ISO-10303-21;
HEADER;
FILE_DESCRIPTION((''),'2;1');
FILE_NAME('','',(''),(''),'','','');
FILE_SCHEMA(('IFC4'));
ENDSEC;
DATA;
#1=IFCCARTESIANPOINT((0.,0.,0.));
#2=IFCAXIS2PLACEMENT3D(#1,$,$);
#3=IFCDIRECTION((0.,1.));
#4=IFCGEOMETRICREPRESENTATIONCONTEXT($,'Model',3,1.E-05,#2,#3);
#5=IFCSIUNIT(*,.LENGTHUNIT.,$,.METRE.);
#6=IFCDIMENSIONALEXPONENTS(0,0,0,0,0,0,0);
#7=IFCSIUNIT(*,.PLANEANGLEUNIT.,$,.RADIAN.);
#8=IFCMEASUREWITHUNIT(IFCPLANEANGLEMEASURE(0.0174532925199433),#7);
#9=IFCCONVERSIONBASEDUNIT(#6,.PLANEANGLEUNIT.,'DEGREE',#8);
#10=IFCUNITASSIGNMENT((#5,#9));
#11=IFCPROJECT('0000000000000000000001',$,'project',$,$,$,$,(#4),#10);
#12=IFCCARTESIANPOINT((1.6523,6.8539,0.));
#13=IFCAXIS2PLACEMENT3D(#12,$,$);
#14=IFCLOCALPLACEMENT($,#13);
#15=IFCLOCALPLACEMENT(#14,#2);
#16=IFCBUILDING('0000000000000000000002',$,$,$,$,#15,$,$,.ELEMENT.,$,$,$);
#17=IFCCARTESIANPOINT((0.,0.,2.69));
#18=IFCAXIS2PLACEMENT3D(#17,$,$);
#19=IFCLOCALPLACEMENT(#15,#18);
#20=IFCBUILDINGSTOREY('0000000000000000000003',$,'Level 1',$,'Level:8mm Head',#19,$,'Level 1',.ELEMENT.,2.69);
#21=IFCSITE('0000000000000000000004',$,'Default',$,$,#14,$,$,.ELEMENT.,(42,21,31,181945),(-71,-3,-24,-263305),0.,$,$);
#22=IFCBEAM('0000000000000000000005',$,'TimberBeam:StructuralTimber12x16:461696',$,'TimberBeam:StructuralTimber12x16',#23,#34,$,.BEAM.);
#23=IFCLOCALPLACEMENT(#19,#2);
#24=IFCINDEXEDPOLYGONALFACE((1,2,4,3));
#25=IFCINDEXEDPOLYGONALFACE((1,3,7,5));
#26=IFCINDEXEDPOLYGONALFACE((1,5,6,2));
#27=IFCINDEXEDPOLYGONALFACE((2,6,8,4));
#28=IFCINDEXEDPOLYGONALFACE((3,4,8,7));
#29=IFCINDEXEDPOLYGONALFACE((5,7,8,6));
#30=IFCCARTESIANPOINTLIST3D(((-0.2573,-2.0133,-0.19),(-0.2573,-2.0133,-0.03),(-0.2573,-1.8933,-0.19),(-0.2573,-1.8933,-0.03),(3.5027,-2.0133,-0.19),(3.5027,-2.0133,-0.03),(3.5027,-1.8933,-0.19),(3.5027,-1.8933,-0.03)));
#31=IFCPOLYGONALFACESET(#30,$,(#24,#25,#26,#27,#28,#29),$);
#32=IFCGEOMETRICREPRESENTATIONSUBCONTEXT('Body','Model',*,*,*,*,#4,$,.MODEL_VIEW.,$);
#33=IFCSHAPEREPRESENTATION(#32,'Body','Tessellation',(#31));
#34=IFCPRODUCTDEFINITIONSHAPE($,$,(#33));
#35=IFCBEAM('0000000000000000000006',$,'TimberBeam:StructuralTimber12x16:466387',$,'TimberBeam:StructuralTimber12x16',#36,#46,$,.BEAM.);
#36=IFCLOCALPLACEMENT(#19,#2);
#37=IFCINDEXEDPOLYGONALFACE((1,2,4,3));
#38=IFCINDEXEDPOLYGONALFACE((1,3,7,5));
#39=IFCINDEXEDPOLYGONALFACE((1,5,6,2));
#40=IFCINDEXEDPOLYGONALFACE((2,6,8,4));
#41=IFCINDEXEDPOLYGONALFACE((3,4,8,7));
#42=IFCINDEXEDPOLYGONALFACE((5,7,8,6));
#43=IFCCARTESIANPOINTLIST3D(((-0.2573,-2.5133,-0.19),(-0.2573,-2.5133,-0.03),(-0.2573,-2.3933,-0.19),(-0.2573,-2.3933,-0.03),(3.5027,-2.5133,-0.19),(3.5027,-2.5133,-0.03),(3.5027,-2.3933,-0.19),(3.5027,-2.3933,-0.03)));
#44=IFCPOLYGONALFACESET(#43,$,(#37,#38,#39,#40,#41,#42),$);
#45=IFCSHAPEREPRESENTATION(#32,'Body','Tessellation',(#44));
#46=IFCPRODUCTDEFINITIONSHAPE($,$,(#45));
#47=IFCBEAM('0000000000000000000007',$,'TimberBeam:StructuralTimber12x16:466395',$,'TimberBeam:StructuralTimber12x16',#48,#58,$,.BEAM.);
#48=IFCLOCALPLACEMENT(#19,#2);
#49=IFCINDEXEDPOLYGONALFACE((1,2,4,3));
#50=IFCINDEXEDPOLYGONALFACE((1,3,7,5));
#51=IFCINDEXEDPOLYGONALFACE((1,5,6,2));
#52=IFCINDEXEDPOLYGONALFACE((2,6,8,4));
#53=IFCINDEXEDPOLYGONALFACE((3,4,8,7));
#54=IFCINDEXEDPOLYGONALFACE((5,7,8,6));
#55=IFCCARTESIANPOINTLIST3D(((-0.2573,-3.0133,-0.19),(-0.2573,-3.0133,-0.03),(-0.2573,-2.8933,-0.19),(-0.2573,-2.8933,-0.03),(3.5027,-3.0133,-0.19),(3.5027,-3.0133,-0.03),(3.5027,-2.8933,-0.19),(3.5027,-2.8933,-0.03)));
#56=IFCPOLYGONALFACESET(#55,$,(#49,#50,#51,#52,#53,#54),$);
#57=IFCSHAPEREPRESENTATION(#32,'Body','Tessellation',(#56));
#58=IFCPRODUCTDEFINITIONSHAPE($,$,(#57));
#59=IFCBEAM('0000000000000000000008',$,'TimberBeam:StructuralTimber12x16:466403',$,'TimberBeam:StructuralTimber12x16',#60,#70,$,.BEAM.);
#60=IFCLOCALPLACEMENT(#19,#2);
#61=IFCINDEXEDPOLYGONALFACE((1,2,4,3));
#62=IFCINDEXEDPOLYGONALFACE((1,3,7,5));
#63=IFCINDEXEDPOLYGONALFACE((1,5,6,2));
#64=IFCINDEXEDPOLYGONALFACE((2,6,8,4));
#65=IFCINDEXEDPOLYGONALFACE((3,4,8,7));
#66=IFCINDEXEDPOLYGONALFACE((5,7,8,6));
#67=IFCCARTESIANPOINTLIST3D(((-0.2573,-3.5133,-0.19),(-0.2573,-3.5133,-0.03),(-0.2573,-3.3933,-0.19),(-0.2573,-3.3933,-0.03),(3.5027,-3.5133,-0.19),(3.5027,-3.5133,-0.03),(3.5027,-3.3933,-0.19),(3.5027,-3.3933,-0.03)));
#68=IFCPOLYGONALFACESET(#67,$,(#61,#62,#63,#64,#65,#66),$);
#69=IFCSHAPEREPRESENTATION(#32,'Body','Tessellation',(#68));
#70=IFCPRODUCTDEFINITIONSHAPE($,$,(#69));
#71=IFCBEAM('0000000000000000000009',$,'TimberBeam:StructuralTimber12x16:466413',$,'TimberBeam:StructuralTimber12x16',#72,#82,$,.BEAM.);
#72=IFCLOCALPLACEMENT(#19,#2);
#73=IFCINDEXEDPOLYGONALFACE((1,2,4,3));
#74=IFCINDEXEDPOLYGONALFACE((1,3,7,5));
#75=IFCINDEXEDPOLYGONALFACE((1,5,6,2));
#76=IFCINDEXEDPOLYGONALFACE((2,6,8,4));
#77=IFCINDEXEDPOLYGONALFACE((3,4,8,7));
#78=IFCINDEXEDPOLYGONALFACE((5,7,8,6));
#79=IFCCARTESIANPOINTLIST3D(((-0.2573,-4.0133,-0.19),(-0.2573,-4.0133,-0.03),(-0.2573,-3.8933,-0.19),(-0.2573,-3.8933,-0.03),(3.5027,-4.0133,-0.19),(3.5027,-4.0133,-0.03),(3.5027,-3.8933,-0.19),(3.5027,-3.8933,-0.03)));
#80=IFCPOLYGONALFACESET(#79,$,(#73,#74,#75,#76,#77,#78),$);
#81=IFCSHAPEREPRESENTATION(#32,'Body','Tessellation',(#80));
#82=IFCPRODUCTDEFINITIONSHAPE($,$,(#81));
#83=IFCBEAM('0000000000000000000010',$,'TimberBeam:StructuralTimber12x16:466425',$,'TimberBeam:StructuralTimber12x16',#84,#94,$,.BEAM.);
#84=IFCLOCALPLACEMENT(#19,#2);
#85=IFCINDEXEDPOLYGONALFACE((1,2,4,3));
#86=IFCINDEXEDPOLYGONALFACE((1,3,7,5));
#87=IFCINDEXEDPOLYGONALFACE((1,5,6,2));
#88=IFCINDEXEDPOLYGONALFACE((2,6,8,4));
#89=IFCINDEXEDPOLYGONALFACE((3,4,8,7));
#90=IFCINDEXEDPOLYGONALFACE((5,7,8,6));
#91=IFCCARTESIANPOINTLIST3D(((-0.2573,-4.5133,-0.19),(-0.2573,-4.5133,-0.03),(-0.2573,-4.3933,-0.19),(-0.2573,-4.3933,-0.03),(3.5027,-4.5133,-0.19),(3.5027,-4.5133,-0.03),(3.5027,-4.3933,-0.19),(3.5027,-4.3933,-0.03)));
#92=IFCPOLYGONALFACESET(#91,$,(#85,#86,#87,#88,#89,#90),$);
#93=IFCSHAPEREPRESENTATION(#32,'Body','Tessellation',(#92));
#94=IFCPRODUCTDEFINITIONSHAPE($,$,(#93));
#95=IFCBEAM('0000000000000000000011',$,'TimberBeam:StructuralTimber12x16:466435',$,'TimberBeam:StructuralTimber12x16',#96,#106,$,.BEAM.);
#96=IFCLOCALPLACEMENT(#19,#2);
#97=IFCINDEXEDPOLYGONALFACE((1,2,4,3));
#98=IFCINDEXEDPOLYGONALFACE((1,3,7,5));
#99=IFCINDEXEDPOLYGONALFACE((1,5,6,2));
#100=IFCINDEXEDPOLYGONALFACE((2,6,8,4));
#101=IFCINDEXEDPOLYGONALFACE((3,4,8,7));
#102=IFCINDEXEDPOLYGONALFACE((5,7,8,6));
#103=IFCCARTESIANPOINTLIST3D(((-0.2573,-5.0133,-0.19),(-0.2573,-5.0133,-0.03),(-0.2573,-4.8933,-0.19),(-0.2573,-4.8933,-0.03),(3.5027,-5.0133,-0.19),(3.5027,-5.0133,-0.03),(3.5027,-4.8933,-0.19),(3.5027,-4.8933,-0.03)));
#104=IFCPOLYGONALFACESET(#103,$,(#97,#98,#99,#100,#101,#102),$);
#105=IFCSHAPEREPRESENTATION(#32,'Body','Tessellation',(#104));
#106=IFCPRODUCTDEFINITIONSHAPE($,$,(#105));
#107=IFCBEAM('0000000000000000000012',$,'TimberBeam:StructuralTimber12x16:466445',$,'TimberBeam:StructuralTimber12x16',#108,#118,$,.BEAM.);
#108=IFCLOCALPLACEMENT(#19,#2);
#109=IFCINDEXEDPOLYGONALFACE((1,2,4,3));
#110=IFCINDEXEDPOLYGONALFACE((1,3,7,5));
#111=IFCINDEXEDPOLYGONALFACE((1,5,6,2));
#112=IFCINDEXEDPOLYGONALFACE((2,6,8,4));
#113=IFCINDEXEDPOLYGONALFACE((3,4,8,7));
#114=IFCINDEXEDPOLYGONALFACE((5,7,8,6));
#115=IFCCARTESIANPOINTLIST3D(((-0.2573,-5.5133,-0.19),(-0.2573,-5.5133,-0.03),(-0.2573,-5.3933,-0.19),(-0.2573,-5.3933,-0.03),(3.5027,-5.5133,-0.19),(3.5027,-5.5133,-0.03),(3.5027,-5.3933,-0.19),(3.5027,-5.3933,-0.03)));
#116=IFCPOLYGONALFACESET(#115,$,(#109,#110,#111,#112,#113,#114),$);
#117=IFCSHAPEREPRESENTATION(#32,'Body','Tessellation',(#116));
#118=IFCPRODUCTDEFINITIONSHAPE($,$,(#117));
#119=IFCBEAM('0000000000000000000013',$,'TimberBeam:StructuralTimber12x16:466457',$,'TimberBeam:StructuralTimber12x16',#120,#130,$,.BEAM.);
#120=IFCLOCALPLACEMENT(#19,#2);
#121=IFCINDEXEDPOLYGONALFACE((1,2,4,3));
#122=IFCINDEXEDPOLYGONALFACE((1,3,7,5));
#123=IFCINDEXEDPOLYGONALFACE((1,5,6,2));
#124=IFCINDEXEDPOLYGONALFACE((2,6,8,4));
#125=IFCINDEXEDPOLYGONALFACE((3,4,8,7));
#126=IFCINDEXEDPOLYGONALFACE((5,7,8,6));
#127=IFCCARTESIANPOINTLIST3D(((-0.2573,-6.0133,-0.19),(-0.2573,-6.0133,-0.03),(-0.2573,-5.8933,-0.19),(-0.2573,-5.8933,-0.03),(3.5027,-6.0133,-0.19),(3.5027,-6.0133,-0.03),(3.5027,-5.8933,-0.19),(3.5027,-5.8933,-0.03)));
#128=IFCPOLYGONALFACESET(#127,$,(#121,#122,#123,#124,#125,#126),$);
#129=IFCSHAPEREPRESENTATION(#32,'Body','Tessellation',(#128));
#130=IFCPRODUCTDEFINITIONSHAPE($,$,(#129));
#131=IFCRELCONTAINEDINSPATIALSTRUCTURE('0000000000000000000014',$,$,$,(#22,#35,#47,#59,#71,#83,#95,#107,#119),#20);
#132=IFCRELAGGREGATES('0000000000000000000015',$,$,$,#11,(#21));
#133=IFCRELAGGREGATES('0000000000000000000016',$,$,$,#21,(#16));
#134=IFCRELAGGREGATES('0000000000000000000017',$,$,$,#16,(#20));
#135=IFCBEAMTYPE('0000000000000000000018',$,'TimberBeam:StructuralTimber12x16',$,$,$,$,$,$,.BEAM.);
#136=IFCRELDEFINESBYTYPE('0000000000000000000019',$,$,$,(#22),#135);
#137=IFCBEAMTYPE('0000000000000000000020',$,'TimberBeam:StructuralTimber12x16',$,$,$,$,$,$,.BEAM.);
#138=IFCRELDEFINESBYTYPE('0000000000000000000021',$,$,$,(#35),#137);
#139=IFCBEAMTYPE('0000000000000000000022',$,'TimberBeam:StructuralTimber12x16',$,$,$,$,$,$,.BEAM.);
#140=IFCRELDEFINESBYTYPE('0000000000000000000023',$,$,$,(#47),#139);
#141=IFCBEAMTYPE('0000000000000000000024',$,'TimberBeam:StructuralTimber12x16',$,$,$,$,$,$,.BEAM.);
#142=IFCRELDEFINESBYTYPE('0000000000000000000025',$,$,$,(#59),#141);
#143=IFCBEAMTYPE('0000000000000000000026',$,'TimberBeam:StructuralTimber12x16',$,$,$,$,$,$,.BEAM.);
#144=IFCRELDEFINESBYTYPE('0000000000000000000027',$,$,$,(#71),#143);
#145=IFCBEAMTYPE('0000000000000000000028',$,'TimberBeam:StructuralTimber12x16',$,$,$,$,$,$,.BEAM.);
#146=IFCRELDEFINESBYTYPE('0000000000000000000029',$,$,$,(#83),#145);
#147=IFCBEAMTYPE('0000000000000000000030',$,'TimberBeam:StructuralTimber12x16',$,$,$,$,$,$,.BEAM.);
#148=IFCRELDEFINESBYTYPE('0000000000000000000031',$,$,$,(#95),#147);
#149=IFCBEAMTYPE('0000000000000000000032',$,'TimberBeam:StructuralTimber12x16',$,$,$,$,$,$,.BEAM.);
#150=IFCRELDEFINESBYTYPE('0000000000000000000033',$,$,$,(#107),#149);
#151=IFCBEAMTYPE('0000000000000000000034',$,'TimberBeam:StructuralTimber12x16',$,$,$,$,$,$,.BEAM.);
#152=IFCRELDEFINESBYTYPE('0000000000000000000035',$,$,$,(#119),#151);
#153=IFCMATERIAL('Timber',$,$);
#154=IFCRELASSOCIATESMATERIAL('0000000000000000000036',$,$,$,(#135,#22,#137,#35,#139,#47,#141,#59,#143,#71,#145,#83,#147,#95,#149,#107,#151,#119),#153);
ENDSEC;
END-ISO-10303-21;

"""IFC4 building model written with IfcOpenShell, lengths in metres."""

from ifc_helpers import new_model, entity, si_unit, converted_unit, direction, frame, origin, place, context, subcontext, project, spatial, indexed_curve, outline, extrude, source, transform, mapped, material, type_object, type_shapes, element, save


model = new_model("IFC4")

# Units and contexts
model_context = context("Model", 3, precision=1e-05, world=origin(), true_north=direction((0.0, 1.0)))
body_context = subcontext(model_context, "Body", "Model", "MODEL_VIEW")
ifc_project = project(units=[si_unit("LENGTHUNIT", "METRE"), converted_unit("PLANEANGLEUNIT", "DEGREE", entity("IfcPlaneAngleMeasure", 0.0174532925199433), si_unit("PLANEANGLEUNIT", "RADIAN"), dimensions=[0, 0, 0, 0, 0, 0, 0])], contexts=[model_context])

# Site, building, storey
site_placement = place(None, frame((1.6523, 6.8539, 0.0)))
site = spatial("IfcSite", under=ifc_project, at=site_placement, Name="Default", CompositionType="ELEMENT", RefLatitude=(42, 21, 31, 181945), RefLongitude=(-71, -3, -24, -263305), RefElevation=0.0)
building_placement = place(site_placement, origin())
building = spatial("IfcBuilding", under=site, at=building_placement, CompositionType="ELEMENT")
storey_placement = place(building_placement, frame((0.0, 0.0, 2.69)))
storey = spatial("IfcBuildingStorey", under=building, at=storey_placement, Name="Level 1", ObjectType="Level:8mm Head", LongName="Level 1", CompositionType="ELEMENT", Elevation=2.69)

# Beams
ifc_material = material(Name="Timber")
beam_type_1 = type_object("IfcBeamType", Name="TimberBeam:StructuralTimber12x16", PredefinedType="BEAM", material=ifc_material)
shared_shape_1 = source(origin(), body_context, "Body", "SweptSolid", [
    extrude(outline(indexed_curve([(-0.08, -0.06), (0.08, -0.06), (0.08, 0.06), (-0.08, 0.06), (-0.08, -0.06)], self_intersect=False)), frame((-0.2573, -1.9533, 2.58), z_axis=(1.0, 0.0, 0.0), x_axis=(0.0, 0.0, -1.0)), (0.0, 0.0, 1.0), 3.76),
])
type_shapes(beam_type_1, [shared_shape_1])
beam_1_placement = place(storey_placement, frame((0.0, 0.0, -2.69)))
element("IfcBeam", 1, at=beam_1_placement, inside=storey, type_object=beam_type_1, material=ifc_material, Name="TimberBeam:StructuralTimber12x16:461696", ObjectType="TimberBeam:StructuralTimber12x16", PredefinedType="BEAM", context=body_context, shape_type="MappedRepresentation", body=[
    mapped(shared_shape_1, transform((0.0, 0.0, 0.0), scale=1.0)),
])
beam_type_2 = type_object("IfcBeamType", Name="TimberBeam:StructuralTimber12x16", PredefinedType="BEAM", material=ifc_material)
shared_shape_2 = source(origin(), body_context, "Body", "SweptSolid", [
    extrude(outline(indexed_curve([(-0.08, -0.06), (0.08, -0.06), (0.08, 0.06), (-0.08, 0.06), (-0.08, -0.06)], self_intersect=False)), frame((-0.2573, -2.4533, 2.58), z_axis=(1.0, 0.0, 0.0), x_axis=(0.0, 0.0, -1.0)), (0.0, 0.0, 1.0), 3.76),
])
type_shapes(beam_type_2, [shared_shape_2])
beam_2_placement = place(storey_placement, frame((0.0, 0.0, -2.69)))
element("IfcBeam", 2, at=beam_2_placement, inside=storey, type_object=beam_type_2, material=ifc_material, Name="TimberBeam:StructuralTimber12x16:466387", ObjectType="TimberBeam:StructuralTimber12x16", PredefinedType="BEAM", context=body_context, shape_type="MappedRepresentation", body=[
    mapped(shared_shape_2, transform((0.0, 0.0, 0.0), scale=1.0)),
])
beam_type_3 = type_object("IfcBeamType", Name="TimberBeam:StructuralTimber12x16", PredefinedType="BEAM", material=ifc_material)
shared_shape_3 = source(origin(), body_context, "Body", "SweptSolid", [
    extrude(outline(indexed_curve([(-0.08, -0.06), (0.08, -0.06), (0.08, 0.06), (-0.08, 0.06), (-0.08, -0.06)], self_intersect=False)), frame((-0.2573, -2.9533, 2.58), z_axis=(1.0, 0.0, 0.0), x_axis=(0.0, 0.0, -1.0)), (0.0, 0.0, 1.0), 3.76),
])
type_shapes(beam_type_3, [shared_shape_3])
beam_3_placement = place(storey_placement, frame((0.0, 0.0, -2.69)))
element("IfcBeam", 3, at=beam_3_placement, inside=storey, type_object=beam_type_3, material=ifc_material, Name="TimberBeam:StructuralTimber12x16:466395", ObjectType="TimberBeam:StructuralTimber12x16", PredefinedType="BEAM", context=body_context, shape_type="MappedRepresentation", body=[
    mapped(shared_shape_3, transform((0.0, 0.0, 0.0), scale=1.0)),
])
beam_type_4 = type_object("IfcBeamType", Name="TimberBeam:StructuralTimber12x16", PredefinedType="BEAM", material=ifc_material)
shared_shape_4 = source(origin(), body_context, "Body", "SweptSolid", [
    extrude(outline(indexed_curve([(-0.08, -0.06), (0.08, -0.06), (0.08, 0.06), (-0.08, 0.06), (-0.08, -0.06)], self_intersect=False)), frame((-0.2573, -3.4533, 2.58), z_axis=(1.0, 0.0, 0.0), x_axis=(0.0, 0.0, -1.0)), (0.0, 0.0, 1.0), 3.76),
])
type_shapes(beam_type_4, [shared_shape_4])
beam_4_placement = place(storey_placement, frame((0.0, 0.0, -2.69)))
element("IfcBeam", 4, at=beam_4_placement, inside=storey, type_object=beam_type_4, material=ifc_material, Name="TimberBeam:StructuralTimber12x16:466403", ObjectType="TimberBeam:StructuralTimber12x16", PredefinedType="BEAM", context=body_context, shape_type="MappedRepresentation", body=[
    mapped(shared_shape_4, transform((0.0, 0.0, 0.0), scale=1.0)),
])
beam_type_5 = type_object("IfcBeamType", Name="TimberBeam:StructuralTimber12x16", PredefinedType="BEAM", material=ifc_material)
shared_shape_5 = source(origin(), body_context, "Body", "SweptSolid", [
    extrude(outline(indexed_curve([(-0.08, -0.06), (0.08, -0.06), (0.08, 0.06), (-0.08, 0.06), (-0.08, -0.06)], self_intersect=False)), frame((-0.2573, -3.9533, 2.58), z_axis=(1.0, 0.0, 0.0), x_axis=(0.0, 0.0, -1.0)), (0.0, 0.0, 1.0), 3.76),
])
type_shapes(beam_type_5, [shared_shape_5])
beam_5_placement = place(storey_placement, frame((0.0, 0.0, -2.69)))
element("IfcBeam", 5, at=beam_5_placement, inside=storey, type_object=beam_type_5, material=ifc_material, Name="TimberBeam:StructuralTimber12x16:466413", ObjectType="TimberBeam:StructuralTimber12x16", PredefinedType="BEAM", context=body_context, shape_type="MappedRepresentation", body=[
    mapped(shared_shape_5, transform((0.0, 0.0, 0.0), scale=1.0)),
])
beam_type_6 = type_object("IfcBeamType", Name="TimberBeam:StructuralTimber12x16", PredefinedType="BEAM", material=ifc_material)
shared_shape_6 = source(origin(), body_context, "Body", "SweptSolid", [
    extrude(outline(indexed_curve([(-0.08, -0.06), (0.08, -0.06), (0.08, 0.06), (-0.08, 0.06), (-0.08, -0.06)], self_intersect=False)), frame((-0.2573, -4.4533, 2.58), z_axis=(1.0, 0.0, 0.0), x_axis=(0.0, 0.0, -1.0)), (0.0, 0.0, 1.0), 3.76),
])
type_shapes(beam_type_6, [shared_shape_6])
beam_6_placement = place(storey_placement, frame((0.0, 0.0, -2.69)))
element("IfcBeam", 6, at=beam_6_placement, inside=storey, type_object=beam_type_6, material=ifc_material, Name="TimberBeam:StructuralTimber12x16:466425", ObjectType="TimberBeam:StructuralTimber12x16", PredefinedType="BEAM", context=body_context, shape_type="MappedRepresentation", body=[
    mapped(shared_shape_6, transform((0.0, 0.0, 0.0), scale=1.0)),
])
beam_type_7 = type_object("IfcBeamType", Name="TimberBeam:StructuralTimber12x16", PredefinedType="BEAM", material=ifc_material)
shared_shape_7 = source(origin(), body_context, "Body", "SweptSolid", [
    extrude(outline(indexed_curve([(-0.08, -0.06), (0.08, -0.06), (0.08, 0.06), (-0.08, 0.06), (-0.08, -0.06)], self_intersect=False)), frame((-0.2573, -4.9533, 2.58), z_axis=(1.0, 0.0, 0.0), x_axis=(0.0, 0.0, -1.0)), (0.0, 0.0, 1.0), 3.76),
])
type_shapes(beam_type_7, [shared_shape_7])
beam_7_placement = place(storey_placement, frame((0.0, 0.0, -2.69)))
element("IfcBeam", 7, at=beam_7_placement, inside=storey, type_object=beam_type_7, material=ifc_material, Name="TimberBeam:StructuralTimber12x16:466435", ObjectType="TimberBeam:StructuralTimber12x16", PredefinedType="BEAM", context=body_context, shape_type="MappedRepresentation", body=[
    mapped(shared_shape_7, transform((0.0, 0.0, 0.0), scale=1.0)),
])
beam_type_8 = type_object("IfcBeamType", Name="TimberBeam:StructuralTimber12x16", PredefinedType="BEAM", material=ifc_material)
shared_shape_8 = source(origin(), body_context, "Body", "SweptSolid", [
    extrude(outline(indexed_curve([(-0.08, -0.06), (0.08, -0.06), (0.08, 0.06), (-0.08, 0.06), (-0.08, -0.06)], self_intersect=False)), frame((-0.2573, -5.4533, 2.58), z_axis=(1.0, 0.0, 0.0), x_axis=(0.0, 0.0, -1.0)), (0.0, 0.0, 1.0), 3.76),
])
type_shapes(beam_type_8, [shared_shape_8])
beam_8_placement = place(storey_placement, frame((0.0, 0.0, -2.69)))
element("IfcBeam", 8, at=beam_8_placement, inside=storey, type_object=beam_type_8, material=ifc_material, Name="TimberBeam:StructuralTimber12x16:466445", ObjectType="TimberBeam:StructuralTimber12x16", PredefinedType="BEAM", context=body_context, shape_type="MappedRepresentation", body=[
    mapped(shared_shape_8, transform((0.0, 0.0, 0.0), scale=1.0)),
])
beam_type_9 = type_object("IfcBeamType", Name="TimberBeam:StructuralTimber12x16", PredefinedType="BEAM", material=ifc_material)
shared_shape_9 = source(origin(), body_context, "Body", "SweptSolid", [
    extrude(outline(indexed_curve([(-0.08, -0.06), (0.08, -0.06), (0.08, 0.06), (-0.08, 0.06), (-0.08, -0.06)], self_intersect=False)), frame((-0.2573, -5.9533, 2.58), z_axis=(1.0, 0.0, 0.0), x_axis=(0.0, 0.0, -1.0)), (0.0, 0.0, 1.0), 3.76),
])
type_shapes(beam_type_9, [shared_shape_9])
beam_9_placement = place(storey_placement, frame((0.0, 0.0, -2.69)))
element("IfcBeam", 9, at=beam_9_placement, inside=storey, type_object=beam_type_9, material=ifc_material, Name="TimberBeam:StructuralTimber12x16:466457", ObjectType="TimberBeam:StructuralTimber12x16", PredefinedType="BEAM", context=body_context, shape_type="MappedRepresentation", body=[
    mapped(shared_shape_9, transform((0.0, 0.0, 0.0), scale=1.0)),
])

save(model, "model.ifc")
